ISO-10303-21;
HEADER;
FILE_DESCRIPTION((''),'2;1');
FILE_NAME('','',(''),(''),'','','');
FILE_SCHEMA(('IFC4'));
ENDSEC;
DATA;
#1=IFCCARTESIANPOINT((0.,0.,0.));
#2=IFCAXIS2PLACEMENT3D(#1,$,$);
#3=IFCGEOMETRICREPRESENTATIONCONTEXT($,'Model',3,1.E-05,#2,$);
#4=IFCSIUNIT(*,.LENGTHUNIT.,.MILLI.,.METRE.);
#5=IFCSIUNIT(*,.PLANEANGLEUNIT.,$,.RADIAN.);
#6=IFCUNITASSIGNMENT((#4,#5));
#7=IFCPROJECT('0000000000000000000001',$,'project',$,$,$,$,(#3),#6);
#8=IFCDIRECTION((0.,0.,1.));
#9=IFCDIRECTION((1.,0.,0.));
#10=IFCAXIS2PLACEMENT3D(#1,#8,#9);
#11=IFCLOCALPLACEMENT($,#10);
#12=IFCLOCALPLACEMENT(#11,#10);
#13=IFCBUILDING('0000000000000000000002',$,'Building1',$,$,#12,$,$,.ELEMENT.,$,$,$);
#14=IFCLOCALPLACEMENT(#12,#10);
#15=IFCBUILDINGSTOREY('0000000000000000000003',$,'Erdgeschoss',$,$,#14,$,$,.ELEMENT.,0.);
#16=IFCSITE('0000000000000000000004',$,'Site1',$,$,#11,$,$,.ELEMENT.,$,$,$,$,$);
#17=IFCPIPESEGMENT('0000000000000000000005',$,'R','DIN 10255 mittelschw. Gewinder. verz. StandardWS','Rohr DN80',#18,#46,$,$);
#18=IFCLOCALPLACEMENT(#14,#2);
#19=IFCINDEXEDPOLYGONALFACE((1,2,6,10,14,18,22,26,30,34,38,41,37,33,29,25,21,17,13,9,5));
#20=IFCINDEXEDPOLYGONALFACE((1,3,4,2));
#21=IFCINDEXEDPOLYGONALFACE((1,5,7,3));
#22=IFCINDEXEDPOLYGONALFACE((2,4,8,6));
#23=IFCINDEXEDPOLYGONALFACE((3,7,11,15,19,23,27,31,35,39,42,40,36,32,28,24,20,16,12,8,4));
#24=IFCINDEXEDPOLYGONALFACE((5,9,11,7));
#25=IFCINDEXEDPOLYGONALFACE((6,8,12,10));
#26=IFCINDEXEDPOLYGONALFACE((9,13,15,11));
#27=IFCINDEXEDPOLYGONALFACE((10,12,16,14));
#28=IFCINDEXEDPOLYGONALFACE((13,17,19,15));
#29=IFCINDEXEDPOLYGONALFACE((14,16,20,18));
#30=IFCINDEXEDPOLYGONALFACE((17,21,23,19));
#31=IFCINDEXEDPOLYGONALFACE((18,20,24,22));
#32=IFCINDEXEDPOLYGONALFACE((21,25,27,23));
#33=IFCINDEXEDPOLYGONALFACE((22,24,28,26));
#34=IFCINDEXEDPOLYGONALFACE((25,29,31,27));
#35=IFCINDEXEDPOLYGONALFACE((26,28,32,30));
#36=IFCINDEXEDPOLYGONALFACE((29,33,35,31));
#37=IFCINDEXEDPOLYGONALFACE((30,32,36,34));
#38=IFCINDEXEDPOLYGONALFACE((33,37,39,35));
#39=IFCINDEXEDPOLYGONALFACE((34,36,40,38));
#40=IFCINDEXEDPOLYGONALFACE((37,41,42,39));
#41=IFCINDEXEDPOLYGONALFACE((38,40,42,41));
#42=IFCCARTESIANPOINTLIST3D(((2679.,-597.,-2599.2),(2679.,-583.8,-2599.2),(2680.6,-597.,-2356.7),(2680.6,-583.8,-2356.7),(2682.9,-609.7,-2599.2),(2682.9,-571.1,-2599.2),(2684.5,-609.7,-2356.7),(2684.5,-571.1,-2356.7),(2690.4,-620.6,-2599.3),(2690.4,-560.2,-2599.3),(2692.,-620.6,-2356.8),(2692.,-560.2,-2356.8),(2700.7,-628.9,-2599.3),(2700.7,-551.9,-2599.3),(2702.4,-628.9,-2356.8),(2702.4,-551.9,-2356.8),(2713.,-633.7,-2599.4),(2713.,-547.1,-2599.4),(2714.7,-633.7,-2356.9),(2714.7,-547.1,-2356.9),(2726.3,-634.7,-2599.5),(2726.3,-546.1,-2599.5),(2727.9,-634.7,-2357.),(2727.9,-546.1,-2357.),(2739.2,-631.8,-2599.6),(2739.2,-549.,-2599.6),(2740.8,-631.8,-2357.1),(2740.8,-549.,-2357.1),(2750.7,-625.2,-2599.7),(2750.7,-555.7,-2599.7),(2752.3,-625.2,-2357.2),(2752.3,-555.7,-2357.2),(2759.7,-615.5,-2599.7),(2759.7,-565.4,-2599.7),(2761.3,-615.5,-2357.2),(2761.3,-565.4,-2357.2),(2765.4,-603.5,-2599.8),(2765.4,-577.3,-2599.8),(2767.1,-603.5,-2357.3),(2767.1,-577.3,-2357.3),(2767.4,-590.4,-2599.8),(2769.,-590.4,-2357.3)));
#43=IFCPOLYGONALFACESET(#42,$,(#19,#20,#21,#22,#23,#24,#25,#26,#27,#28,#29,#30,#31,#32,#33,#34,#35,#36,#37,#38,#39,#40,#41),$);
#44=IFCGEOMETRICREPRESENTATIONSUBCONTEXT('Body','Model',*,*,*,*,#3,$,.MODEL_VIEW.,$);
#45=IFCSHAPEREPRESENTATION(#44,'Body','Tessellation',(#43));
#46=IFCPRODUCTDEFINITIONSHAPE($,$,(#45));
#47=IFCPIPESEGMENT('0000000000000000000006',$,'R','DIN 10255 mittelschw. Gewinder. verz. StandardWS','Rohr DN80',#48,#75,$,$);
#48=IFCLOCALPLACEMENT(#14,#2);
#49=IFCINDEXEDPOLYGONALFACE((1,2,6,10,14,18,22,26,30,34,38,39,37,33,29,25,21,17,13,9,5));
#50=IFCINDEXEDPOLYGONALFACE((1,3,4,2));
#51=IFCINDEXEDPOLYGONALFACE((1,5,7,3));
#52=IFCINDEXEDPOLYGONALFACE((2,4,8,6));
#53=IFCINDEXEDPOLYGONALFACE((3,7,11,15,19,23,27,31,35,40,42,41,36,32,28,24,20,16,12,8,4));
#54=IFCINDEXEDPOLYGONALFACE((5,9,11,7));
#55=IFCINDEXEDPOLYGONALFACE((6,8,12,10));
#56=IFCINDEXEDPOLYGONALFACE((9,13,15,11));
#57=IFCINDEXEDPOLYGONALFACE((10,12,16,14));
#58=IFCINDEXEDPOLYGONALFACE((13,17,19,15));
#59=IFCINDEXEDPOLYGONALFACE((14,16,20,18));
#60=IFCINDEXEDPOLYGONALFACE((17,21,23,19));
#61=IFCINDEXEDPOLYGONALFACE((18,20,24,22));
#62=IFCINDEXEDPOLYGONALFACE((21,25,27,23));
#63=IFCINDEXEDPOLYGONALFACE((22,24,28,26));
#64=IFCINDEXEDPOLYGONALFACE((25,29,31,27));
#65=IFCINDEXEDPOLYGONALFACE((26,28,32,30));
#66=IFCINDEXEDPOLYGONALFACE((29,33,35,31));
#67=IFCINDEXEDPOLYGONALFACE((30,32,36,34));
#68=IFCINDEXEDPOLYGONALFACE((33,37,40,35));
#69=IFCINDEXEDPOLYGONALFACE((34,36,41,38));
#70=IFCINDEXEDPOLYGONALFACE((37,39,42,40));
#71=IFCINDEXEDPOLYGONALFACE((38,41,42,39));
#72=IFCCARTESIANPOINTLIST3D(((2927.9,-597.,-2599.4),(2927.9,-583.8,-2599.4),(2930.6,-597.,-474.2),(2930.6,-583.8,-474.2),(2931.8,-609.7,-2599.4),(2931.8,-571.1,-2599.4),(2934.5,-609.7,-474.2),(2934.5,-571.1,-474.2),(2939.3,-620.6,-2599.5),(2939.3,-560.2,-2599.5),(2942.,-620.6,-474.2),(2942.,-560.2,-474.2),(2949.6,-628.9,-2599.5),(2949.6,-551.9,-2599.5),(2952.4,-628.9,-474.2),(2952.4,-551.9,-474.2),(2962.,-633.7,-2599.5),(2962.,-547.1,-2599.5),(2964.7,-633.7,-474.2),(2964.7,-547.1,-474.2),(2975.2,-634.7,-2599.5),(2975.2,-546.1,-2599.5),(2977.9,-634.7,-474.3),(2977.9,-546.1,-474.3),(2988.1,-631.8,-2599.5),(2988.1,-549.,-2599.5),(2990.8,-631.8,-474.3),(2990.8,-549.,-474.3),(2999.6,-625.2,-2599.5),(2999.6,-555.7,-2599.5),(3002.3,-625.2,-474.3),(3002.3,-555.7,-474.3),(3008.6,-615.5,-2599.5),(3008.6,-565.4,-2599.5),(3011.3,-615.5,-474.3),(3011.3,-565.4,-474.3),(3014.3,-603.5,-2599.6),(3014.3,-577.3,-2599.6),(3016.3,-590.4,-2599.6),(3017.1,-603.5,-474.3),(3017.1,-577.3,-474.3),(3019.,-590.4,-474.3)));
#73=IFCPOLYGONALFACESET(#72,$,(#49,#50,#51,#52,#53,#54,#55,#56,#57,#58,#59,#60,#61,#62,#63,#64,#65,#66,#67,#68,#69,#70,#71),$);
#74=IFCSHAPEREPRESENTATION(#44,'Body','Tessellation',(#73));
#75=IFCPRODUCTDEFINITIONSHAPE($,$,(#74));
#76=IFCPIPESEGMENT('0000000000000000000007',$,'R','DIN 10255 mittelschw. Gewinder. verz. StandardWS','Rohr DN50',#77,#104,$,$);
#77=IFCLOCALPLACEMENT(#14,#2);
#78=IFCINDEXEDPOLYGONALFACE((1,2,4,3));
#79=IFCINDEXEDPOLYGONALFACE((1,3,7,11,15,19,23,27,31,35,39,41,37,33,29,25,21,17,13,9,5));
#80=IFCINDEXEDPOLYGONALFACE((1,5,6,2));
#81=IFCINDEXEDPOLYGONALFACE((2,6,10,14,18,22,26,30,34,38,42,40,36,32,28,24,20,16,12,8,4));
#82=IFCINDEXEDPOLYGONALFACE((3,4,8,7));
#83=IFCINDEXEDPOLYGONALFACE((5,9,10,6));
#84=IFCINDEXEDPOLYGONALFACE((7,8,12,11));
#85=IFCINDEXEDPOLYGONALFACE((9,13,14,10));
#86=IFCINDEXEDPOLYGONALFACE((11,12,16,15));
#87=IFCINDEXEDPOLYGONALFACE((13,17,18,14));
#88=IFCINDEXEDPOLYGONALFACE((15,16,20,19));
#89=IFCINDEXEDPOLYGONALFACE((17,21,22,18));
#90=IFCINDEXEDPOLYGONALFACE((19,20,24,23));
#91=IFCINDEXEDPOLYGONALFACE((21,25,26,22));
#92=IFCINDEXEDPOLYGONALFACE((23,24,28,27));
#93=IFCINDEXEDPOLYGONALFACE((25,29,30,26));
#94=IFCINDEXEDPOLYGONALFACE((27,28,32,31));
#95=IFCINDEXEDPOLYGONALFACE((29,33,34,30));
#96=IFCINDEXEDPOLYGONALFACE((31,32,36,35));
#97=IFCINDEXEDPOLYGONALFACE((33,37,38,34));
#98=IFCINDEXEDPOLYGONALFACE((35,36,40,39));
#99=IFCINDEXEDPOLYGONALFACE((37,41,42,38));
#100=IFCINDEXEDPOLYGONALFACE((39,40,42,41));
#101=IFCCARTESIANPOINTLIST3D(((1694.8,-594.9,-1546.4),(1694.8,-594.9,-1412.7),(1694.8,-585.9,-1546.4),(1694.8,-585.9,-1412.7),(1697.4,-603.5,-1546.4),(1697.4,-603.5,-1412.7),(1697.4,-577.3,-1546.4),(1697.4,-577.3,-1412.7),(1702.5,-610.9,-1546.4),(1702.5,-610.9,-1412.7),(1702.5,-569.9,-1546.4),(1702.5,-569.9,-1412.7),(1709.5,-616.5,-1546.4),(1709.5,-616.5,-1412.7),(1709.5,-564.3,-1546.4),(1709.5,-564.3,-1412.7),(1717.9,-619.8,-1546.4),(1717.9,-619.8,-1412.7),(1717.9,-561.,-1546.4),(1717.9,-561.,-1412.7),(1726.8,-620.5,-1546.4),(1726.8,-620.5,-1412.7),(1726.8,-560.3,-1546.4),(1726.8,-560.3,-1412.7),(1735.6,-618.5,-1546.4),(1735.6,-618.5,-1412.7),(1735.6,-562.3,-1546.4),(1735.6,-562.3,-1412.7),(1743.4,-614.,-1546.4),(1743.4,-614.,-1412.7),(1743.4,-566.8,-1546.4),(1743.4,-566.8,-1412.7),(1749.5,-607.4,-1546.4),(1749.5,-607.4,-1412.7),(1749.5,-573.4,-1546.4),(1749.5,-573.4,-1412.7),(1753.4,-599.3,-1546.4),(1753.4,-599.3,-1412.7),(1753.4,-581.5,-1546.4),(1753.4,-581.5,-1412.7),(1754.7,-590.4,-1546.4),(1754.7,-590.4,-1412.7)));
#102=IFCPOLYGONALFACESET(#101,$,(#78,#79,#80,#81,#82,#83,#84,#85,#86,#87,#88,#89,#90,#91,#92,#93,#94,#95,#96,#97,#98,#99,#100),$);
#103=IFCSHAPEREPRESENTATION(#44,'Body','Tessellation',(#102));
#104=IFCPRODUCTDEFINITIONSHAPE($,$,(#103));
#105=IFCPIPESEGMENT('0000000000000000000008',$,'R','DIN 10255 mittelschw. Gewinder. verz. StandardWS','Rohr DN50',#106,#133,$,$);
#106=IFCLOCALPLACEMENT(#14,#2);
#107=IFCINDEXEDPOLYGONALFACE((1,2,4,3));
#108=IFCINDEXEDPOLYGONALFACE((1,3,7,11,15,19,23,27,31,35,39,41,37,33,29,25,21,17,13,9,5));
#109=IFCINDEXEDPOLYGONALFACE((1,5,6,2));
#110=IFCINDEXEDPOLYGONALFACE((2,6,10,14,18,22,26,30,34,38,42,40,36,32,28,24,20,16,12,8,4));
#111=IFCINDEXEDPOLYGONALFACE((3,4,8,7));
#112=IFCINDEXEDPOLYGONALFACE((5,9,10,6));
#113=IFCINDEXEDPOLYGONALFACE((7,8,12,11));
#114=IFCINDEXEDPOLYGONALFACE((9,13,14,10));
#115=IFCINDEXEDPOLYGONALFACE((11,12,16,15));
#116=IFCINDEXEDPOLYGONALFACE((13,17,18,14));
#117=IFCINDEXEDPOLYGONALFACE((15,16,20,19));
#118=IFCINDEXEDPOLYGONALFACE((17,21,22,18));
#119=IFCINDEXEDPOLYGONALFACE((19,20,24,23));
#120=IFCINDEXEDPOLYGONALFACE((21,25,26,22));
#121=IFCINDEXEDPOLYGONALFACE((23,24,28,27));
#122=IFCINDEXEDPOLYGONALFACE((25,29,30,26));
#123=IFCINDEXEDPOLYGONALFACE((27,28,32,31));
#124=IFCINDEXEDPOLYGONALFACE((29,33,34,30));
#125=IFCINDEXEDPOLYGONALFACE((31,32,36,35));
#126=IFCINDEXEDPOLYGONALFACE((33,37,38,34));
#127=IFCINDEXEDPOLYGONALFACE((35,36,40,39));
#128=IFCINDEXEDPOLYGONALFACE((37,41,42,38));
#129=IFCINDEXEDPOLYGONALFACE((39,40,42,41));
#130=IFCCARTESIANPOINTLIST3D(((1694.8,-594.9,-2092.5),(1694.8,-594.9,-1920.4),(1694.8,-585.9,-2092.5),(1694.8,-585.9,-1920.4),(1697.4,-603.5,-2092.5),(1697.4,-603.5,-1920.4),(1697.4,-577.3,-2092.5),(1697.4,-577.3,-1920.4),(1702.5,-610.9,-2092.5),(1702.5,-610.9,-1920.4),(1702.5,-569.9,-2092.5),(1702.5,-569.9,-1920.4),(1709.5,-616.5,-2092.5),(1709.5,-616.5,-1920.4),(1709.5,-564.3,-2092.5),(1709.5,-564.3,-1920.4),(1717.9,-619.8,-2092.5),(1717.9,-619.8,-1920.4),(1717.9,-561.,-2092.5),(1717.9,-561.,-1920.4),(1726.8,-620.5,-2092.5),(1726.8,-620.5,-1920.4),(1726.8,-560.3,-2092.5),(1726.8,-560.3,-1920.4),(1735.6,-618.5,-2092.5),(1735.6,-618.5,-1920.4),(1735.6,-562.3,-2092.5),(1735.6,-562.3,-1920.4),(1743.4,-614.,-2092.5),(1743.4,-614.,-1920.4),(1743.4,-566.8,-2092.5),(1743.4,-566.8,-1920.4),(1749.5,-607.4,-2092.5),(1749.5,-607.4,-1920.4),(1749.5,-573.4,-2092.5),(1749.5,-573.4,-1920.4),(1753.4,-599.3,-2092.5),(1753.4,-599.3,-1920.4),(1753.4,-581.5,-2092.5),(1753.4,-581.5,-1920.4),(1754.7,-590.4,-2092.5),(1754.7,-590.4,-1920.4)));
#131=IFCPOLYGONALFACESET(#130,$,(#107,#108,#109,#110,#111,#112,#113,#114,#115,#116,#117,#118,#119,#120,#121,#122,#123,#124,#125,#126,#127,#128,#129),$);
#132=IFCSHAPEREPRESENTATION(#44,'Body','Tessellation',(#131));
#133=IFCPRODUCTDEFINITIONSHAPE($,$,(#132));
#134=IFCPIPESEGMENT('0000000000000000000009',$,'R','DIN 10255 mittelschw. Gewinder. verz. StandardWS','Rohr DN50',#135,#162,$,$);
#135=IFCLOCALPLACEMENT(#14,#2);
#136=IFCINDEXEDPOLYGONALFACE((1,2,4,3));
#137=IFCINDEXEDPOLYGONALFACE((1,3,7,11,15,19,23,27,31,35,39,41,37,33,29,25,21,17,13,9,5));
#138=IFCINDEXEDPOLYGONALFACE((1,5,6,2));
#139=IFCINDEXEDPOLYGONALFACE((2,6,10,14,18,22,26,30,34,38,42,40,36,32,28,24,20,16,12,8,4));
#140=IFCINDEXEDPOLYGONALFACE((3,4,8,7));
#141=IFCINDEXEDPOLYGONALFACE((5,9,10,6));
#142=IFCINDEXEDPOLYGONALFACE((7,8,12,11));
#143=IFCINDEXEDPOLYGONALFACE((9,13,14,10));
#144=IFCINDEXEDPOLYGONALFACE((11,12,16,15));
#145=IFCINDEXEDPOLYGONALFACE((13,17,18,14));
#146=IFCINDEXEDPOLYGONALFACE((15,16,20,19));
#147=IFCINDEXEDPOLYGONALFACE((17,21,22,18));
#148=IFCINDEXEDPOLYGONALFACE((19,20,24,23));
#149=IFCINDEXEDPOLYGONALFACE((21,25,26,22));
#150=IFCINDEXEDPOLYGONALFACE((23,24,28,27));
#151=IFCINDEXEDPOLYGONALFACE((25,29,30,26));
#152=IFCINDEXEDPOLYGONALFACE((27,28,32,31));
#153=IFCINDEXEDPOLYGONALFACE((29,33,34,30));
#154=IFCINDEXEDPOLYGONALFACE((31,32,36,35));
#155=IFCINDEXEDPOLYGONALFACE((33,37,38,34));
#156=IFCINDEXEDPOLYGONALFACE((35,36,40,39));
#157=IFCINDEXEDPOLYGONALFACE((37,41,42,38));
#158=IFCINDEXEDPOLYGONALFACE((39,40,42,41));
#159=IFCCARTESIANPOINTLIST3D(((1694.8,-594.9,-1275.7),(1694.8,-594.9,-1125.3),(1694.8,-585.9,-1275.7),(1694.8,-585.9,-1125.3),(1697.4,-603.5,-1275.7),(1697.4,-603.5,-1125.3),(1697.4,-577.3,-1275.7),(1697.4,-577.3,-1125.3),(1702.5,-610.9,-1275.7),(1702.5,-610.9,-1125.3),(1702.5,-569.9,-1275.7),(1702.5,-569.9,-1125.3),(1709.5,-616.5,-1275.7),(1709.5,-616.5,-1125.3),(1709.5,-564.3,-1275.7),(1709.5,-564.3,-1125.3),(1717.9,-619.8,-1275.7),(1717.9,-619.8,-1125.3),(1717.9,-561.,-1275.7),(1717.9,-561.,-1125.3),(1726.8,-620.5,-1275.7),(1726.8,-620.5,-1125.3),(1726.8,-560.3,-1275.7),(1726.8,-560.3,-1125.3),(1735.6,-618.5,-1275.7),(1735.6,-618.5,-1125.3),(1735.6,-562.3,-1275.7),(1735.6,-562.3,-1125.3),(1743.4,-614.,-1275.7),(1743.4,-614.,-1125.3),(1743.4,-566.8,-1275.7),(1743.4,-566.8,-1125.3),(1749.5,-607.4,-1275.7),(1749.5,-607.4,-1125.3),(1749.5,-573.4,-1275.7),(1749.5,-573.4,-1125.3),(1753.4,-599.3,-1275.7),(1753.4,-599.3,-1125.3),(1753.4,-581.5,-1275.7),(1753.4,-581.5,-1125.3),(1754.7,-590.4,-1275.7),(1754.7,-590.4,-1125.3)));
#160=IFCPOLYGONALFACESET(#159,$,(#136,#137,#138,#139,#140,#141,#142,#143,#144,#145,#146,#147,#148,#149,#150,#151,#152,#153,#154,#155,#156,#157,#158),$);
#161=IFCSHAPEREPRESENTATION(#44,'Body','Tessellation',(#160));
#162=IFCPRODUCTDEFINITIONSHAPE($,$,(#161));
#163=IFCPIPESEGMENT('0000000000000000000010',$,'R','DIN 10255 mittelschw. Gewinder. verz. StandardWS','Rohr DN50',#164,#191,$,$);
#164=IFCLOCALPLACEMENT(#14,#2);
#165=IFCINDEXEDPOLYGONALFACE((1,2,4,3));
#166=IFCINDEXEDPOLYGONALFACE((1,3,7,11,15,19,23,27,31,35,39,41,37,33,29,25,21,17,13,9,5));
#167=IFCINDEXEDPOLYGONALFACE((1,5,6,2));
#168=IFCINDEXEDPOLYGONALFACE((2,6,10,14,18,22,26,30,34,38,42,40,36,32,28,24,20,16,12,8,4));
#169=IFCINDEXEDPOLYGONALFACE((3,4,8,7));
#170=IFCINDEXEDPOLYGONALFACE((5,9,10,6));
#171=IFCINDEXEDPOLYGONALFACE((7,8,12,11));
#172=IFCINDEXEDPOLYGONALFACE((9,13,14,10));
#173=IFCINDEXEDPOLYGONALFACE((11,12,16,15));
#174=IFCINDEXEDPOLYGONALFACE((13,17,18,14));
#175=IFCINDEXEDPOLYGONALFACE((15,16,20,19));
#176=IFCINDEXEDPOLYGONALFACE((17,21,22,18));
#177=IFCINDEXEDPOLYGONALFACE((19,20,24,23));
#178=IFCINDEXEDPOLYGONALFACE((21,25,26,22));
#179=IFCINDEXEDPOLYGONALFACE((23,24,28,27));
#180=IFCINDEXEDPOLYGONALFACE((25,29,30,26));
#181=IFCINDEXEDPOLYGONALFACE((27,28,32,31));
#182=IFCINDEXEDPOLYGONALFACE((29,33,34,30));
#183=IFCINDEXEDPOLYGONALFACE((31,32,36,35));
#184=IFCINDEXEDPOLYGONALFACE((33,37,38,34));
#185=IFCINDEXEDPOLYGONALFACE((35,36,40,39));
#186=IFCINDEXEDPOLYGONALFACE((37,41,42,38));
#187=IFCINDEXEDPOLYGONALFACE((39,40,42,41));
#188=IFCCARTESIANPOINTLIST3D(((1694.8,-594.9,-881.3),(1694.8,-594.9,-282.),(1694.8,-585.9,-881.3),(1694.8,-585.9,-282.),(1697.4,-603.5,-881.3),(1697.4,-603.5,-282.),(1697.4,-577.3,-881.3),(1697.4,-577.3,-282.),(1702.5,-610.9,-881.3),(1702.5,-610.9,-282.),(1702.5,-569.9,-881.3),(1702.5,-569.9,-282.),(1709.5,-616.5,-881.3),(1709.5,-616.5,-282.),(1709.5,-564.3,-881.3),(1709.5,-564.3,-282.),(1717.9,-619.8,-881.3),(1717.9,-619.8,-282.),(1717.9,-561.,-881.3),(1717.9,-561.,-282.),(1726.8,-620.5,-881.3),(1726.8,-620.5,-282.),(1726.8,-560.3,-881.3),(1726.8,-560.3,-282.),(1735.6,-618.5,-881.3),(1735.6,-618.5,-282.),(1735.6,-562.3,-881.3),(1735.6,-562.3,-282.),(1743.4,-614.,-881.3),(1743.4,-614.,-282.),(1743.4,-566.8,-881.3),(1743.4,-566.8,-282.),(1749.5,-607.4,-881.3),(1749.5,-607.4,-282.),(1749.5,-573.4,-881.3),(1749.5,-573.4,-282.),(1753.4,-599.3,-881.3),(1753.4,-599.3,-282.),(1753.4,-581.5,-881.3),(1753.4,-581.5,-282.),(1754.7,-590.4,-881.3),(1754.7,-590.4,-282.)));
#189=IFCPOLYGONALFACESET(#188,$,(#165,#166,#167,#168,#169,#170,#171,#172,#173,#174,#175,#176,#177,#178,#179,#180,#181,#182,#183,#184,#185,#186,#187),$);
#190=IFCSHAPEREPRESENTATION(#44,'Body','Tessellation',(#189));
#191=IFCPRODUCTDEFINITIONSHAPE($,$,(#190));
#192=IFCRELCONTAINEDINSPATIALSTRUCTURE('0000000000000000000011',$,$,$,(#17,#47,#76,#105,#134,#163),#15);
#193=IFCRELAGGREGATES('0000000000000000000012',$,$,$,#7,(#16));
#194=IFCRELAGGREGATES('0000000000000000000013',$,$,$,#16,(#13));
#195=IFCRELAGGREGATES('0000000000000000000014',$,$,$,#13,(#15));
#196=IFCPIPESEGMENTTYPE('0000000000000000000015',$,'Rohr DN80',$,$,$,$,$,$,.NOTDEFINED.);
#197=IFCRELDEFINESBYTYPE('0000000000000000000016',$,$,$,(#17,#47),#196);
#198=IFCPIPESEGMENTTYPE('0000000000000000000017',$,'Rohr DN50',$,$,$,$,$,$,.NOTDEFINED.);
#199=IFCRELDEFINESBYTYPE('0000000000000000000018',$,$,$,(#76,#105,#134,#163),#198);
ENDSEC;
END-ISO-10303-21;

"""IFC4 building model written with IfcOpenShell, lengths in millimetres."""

from ifc_helpers import new_model, si_unit, frame, origin, origin_with_axes, origin_2d_with_axis, place, context, subcontext, project, spatial, circle, extrude, type_object, element, save


model = new_model("IFC4")

# Units and contexts
model_context = context("Model", 3, precision=1e-05, world=origin())
body_context = subcontext(model_context, "Body", "Model", "MODEL_VIEW")
ifc_project = project(units=[si_unit("LENGTHUNIT", "METRE", prefix="MILLI"), si_unit("PLANEANGLEUNIT", "RADIAN")], contexts=[model_context])

# Site, building, storey
site_placement = place(None, origin_with_axes())
site = spatial("IfcSite", under=ifc_project, at=site_placement, Name="Site1", CompositionType="ELEMENT")
building_placement = place(site_placement, origin_with_axes())
building = spatial("IfcBuilding", under=site, at=building_placement, Name="Building1", CompositionType="ELEMENT")
storey_placement = place(building_placement, origin_with_axes())
storey = spatial("IfcBuildingStorey", under=building, at=storey_placement, Name="Erdgeschoss", CompositionType="ELEMENT", Elevation=0.0)

# Pipe segments
pipe_segment_type_1 = type_object("IfcPipeSegmentType", Name="Rohr DN80", PredefinedType="NOTDEFINED")
pipe_segment_1_placement = place(storey_placement, frame((2723.8, -590.6, -2478.2), z_axis=(0.0, 0.0, 1.0), x_axis=(1.0, 0.0, 0.0)))
element("IfcPipeSegment", 1, at=pipe_segment_1_placement, inside=storey, type_object=pipe_segment_type_1, Name="R", Description="DIN 10255 mittelschw. Gewinder. verz. StandardWS", ObjectType="Rohr DN80", context=body_context, shape_type="SolidModel", body=[
    extrude(circle(Radius=44.5, at=origin_2d_with_axis()), frame((-0.8, 0.1, -121.3), z_axis=(0.006764, 0.0, 0.999977), x_axis=(1.0, 0.0, 0.0)), (0.0, 0.0, 1.0), 242.5),
])
pipe_segment_2_placement = place(storey_placement, frame((2973.2, -590.6, -1536.9), z_axis=(0.0, 0.0, 1.0), x_axis=(1.0, 0.0, 0.0)))
element("IfcPipeSegment", 2, at=pipe_segment_2_placement, inside=storey, type_object=pipe_segment_type_1, Name="R", Description="DIN 10255 mittelschw. Gewinder. verz. StandardWS", ObjectType="Rohr DN80", context=body_context, shape_type="SolidModel", body=[
    extrude(circle(Radius=44.5, at=origin_2d_with_axis()), frame((-1.4, 0.1, -1062.6), z_axis=(0.001276, 0.0, 0.999999), x_axis=(1.0, 0.0, 0.0)), (0.0, 0.0, 1.0), 2125.3),
])
pipe_segment_type_2 = type_object("IfcPipeSegmentType", Name="Rohr DN50", PredefinedType="NOTDEFINED")
pipe_segment_3_placement = place(storey_placement, frame((1724.6, -590.6, -1479.6), z_axis=(0.0, 0.0, 1.0), x_axis=(1.0, 0.0, 0.0)))
element("IfcPipeSegment", 3, at=pipe_segment_3_placement, inside=storey, type_object=pipe_segment_type_2, Name="R", Description="DIN 10255 mittelschw. Gewinder. verz. StandardWS", ObjectType="Rohr DN50", context=body_context, shape_type="SolidModel", body=[
    extrude(circle(Radius=30.1, at=origin_2d_with_axis()), frame((0.0, 0.1, -66.8), z_axis=(0.0, 0.0, 1.0), x_axis=(1.0, 0.0, 0.0)), (0.0, 0.0, 1.0), 133.7),
])
pipe_segment_4_placement = place(storey_placement, frame((1724.6, -590.6, -2006.4), z_axis=(0.0, 0.0, 1.0), x_axis=(1.0, 0.0, 0.0)))
element("IfcPipeSegment", 4, at=pipe_segment_4_placement, inside=storey, type_object=pipe_segment_type_2, Name="R", Description="DIN 10255 mittelschw. Gewinder. verz. StandardWS", ObjectType="Rohr DN50", context=body_context, shape_type="SolidModel", body=[
    extrude(circle(Radius=30.1, at=origin_2d_with_axis()), frame((0.0, 0.1, -86.1), z_axis=(0.0, 0.0, 1.0), x_axis=(1.0, 0.0, 0.0)), (0.0, 0.0, 1.0), 172.1),
])
pipe_segment_5_placement = place(storey_placement, frame((1724.6, -590.6, -1200.5), z_axis=(0.0, 0.0, 1.0), x_axis=(1.0, 0.0, 0.0)))
element("IfcPipeSegment", 5, at=pipe_segment_5_placement, inside=storey, type_object=pipe_segment_type_2, Name="R", Description="DIN 10255 mittelschw. Gewinder. verz. StandardWS", ObjectType="Rohr DN50", context=body_context, shape_type="SolidModel", body=[
    extrude(circle(Radius=30.1, at=origin_2d_with_axis()), frame((0.0, 0.1, -75.2), z_axis=(0.0, 0.0, 1.0), x_axis=(1.0, 0.0, 0.0)), (0.0, 0.0, 1.0), 150.5),
])
pipe_segment_6_placement = place(storey_placement, frame((1724.6, -590.6, -581.6), z_axis=(0.0, 0.0, 1.0), x_axis=(1.0, 0.0, 0.0)))
element("IfcPipeSegment", 6, at=pipe_segment_6_placement, inside=storey, type_object=pipe_segment_type_2, Name="R", Description="DIN 10255 mittelschw. Gewinder. verz. StandardWS", ObjectType="Rohr DN50", context=body_context, shape_type="SolidModel", body=[
    extrude(circle(Radius=30.1, at=origin_2d_with_axis()), frame((0.0, 0.1, -299.6), z_axis=(0.0, 0.0, 1.0), x_axis=(1.0, 0.0, 0.0)), (0.0, 0.0, 1.0), 599.3),
])

save(model, "model.ifc")
